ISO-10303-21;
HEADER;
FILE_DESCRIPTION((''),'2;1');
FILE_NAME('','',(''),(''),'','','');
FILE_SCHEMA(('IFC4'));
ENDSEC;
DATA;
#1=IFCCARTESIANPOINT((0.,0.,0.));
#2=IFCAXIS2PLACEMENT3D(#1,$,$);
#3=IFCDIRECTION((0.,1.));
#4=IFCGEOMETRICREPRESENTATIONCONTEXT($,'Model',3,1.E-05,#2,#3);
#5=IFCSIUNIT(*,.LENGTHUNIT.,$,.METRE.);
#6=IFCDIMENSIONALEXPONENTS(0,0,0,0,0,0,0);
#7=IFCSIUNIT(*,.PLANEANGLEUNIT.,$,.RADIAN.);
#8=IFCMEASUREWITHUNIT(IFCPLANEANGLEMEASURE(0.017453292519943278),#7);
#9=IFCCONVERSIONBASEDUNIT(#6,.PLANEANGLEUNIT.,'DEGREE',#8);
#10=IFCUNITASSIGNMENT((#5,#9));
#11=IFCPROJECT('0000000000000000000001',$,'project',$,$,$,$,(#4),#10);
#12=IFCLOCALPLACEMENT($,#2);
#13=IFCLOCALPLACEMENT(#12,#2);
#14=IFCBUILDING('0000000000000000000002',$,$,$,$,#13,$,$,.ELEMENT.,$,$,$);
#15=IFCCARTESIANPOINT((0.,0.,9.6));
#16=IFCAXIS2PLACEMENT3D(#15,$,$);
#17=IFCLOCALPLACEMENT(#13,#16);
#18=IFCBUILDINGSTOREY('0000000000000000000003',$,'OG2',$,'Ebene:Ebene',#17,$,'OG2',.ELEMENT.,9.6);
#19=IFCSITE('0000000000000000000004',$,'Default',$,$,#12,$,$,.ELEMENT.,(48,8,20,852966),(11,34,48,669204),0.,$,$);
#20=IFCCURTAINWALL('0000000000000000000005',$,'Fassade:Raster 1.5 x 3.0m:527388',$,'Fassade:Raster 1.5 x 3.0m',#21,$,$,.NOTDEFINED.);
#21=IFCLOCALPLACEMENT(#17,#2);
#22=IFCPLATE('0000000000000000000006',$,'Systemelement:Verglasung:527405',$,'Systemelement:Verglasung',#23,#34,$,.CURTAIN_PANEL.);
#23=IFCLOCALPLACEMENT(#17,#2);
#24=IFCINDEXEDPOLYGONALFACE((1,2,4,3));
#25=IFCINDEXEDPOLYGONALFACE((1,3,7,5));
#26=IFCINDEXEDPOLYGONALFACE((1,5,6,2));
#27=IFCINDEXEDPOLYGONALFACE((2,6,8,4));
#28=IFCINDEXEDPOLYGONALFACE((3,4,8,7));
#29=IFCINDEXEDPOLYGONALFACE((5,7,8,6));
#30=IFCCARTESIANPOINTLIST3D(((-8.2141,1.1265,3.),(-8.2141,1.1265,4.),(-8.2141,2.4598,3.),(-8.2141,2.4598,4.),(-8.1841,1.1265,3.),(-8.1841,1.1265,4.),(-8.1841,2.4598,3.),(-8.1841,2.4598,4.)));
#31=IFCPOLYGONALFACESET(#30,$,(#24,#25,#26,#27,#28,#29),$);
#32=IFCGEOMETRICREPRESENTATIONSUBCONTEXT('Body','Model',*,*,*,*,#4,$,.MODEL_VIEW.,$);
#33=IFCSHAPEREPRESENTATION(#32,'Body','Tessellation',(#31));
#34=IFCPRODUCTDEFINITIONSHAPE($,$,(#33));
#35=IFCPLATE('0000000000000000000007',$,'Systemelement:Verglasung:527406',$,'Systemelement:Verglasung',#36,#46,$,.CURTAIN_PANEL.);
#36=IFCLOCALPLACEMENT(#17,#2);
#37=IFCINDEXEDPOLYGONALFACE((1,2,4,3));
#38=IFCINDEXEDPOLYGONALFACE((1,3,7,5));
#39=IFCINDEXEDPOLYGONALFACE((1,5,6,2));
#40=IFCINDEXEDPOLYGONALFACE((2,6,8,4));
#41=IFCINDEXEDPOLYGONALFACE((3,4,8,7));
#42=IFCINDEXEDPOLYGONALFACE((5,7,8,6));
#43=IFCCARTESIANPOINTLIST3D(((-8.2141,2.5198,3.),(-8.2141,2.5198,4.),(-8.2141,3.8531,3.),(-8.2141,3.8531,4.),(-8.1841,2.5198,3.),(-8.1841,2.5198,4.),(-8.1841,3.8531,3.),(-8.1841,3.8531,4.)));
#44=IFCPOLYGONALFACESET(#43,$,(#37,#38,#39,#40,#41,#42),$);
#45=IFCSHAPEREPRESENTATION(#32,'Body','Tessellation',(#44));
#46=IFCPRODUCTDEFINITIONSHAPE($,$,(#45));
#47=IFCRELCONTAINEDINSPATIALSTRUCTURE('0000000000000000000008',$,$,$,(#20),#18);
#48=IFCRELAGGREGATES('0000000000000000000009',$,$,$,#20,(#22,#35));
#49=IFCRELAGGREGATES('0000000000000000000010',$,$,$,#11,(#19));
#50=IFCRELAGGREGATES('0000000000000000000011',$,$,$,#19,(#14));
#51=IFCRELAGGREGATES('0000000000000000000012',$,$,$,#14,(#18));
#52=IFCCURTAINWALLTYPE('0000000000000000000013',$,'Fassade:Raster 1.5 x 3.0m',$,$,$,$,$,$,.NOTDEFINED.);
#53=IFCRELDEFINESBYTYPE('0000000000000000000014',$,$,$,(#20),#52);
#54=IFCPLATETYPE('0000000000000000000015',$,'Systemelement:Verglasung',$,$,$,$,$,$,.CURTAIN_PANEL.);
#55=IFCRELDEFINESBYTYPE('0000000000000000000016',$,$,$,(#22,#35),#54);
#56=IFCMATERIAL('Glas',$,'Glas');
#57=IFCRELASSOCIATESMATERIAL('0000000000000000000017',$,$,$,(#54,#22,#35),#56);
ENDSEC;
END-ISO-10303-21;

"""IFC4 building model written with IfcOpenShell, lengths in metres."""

from ifc_helpers import new_model, entity, si_unit, converted_unit, direction, frame, origin, place, context, subcontext, project, spatial, indexed_curve, outline, extrude, source, transform, mapped, material, type_object, type_shapes, element, aggregate, save


model = new_model("IFC4")

# Units and contexts
model_context = context("Model", 3, precision=1e-05, world=origin(), true_north=direction((0.0, 1.0)))
body_context = subcontext(model_context, "Body", "Model", "MODEL_VIEW")
ifc_project = project(units=[si_unit("LENGTHUNIT", "METRE"), converted_unit("PLANEANGLEUNIT", "DEGREE", entity("IfcPlaneAngleMeasure", 0.017453292519943278), si_unit("PLANEANGLEUNIT", "RADIAN"), dimensions=[0, 0, 0, 0, 0, 0, 0])], contexts=[model_context])

# Site, building, storey
site_placement = place(None, origin())
site = spatial("IfcSite", under=ifc_project, at=site_placement, Name="Default", CompositionType="ELEMENT", RefLatitude=(48, 8, 20, 852966), RefLongitude=(11, 34, 48, 669204), RefElevation=0.0)
building_placement = place(site_placement, origin())
building = spatial("IfcBuilding", under=site, at=building_placement, CompositionType="ELEMENT")
storey_placement = place(building_placement, frame((0.0, 0.0, 9.6)))
storey = spatial("IfcBuildingStorey", under=building, at=storey_placement, Name="OG2", ObjectType="Ebene:Ebene", LongName="OG2", CompositionType="ELEMENT", Elevation=9.6)

# Curtain wall
curtain_wall_type = type_object("IfcCurtainWallType", Name="Fassade:Raster 1.5 x 3.0m", PredefinedType="NOTDEFINED")
curtain_wall_placement = place(storey_placement, frame((0.0, 0.0, -9.6)))
curtain_wall = element("IfcCurtainWall", 1, at=curtain_wall_placement, inside=storey, type_object=curtain_wall_type, Name="Fassade:Raster 1.5 x 3.0m:527388", ObjectType="Fassade:Raster 1.5 x 3.0m", PredefinedType="NOTDEFINED")

# Plates
ifc_material_1 = material(Name="Glas", Category="Glas")
plate_type_1 = type_object("IfcPlateType", Name="Systemelement:Verglasung", PredefinedType="CURTAIN_PANEL", material=ifc_material_1)
shared_shape_1 = source(origin(), body_context, "Body", "SweptSolid", [
    extrude(outline(indexed_curve([(-0.015, -0.6667), (0.015, -0.6667), (0.015, 0.6667), (-0.015, 0.6667), (-0.015, -0.6667)], self_intersect=False)), frame((0.0, 0.0, 0.0), z_axis=(0.0, 0.0, 1.0), x_axis=(0.0, 1.0, 0.0)), (0.0, 0.0, 1.0), 1.0),
])
type_shapes(plate_type_1, [shared_shape_1])
plate_1_placement = place(curtain_wall_placement, frame((-8.1991, 1.7931, 12.6), z_axis=(0.0, 0.0, 1.0), x_axis=(0.0, 1.0, 0.0)))
plate_1 = element("IfcPlate", 2, at=plate_1_placement, type_object=plate_type_1, material=ifc_material_1, Name="Systemelement:Verglasung:527405", ObjectType="Systemelement:Verglasung", PredefinedType="CURTAIN_PANEL", context=body_context, shape_type="MappedRepresentation", body=[
    mapped(shared_shape_1, transform((0.0, 0.0, 0.0), scale=1.0)),
])
plate_2_placement = place(curtain_wall_placement, frame((-8.1991, 3.1865, 12.6), z_axis=(0.0, 0.0, 1.0), x_axis=(0.0, 1.0, 0.0)))
plate_2 = element("IfcPlate", 3, at=plate_2_placement, type_object=plate_type_1, material=ifc_material_1, Name="Systemelement:Verglasung:527406", ObjectType="Systemelement:Verglasung", PredefinedType="CURTAIN_PANEL", context=body_context, shape_type="MappedRepresentation", body=[
    mapped(shared_shape_1, transform((0.0, 0.0, 0.0), scale=1.0)),
])
aggregate(curtain_wall, [plate_1, plate_2])

save(model, "model.ifc")
